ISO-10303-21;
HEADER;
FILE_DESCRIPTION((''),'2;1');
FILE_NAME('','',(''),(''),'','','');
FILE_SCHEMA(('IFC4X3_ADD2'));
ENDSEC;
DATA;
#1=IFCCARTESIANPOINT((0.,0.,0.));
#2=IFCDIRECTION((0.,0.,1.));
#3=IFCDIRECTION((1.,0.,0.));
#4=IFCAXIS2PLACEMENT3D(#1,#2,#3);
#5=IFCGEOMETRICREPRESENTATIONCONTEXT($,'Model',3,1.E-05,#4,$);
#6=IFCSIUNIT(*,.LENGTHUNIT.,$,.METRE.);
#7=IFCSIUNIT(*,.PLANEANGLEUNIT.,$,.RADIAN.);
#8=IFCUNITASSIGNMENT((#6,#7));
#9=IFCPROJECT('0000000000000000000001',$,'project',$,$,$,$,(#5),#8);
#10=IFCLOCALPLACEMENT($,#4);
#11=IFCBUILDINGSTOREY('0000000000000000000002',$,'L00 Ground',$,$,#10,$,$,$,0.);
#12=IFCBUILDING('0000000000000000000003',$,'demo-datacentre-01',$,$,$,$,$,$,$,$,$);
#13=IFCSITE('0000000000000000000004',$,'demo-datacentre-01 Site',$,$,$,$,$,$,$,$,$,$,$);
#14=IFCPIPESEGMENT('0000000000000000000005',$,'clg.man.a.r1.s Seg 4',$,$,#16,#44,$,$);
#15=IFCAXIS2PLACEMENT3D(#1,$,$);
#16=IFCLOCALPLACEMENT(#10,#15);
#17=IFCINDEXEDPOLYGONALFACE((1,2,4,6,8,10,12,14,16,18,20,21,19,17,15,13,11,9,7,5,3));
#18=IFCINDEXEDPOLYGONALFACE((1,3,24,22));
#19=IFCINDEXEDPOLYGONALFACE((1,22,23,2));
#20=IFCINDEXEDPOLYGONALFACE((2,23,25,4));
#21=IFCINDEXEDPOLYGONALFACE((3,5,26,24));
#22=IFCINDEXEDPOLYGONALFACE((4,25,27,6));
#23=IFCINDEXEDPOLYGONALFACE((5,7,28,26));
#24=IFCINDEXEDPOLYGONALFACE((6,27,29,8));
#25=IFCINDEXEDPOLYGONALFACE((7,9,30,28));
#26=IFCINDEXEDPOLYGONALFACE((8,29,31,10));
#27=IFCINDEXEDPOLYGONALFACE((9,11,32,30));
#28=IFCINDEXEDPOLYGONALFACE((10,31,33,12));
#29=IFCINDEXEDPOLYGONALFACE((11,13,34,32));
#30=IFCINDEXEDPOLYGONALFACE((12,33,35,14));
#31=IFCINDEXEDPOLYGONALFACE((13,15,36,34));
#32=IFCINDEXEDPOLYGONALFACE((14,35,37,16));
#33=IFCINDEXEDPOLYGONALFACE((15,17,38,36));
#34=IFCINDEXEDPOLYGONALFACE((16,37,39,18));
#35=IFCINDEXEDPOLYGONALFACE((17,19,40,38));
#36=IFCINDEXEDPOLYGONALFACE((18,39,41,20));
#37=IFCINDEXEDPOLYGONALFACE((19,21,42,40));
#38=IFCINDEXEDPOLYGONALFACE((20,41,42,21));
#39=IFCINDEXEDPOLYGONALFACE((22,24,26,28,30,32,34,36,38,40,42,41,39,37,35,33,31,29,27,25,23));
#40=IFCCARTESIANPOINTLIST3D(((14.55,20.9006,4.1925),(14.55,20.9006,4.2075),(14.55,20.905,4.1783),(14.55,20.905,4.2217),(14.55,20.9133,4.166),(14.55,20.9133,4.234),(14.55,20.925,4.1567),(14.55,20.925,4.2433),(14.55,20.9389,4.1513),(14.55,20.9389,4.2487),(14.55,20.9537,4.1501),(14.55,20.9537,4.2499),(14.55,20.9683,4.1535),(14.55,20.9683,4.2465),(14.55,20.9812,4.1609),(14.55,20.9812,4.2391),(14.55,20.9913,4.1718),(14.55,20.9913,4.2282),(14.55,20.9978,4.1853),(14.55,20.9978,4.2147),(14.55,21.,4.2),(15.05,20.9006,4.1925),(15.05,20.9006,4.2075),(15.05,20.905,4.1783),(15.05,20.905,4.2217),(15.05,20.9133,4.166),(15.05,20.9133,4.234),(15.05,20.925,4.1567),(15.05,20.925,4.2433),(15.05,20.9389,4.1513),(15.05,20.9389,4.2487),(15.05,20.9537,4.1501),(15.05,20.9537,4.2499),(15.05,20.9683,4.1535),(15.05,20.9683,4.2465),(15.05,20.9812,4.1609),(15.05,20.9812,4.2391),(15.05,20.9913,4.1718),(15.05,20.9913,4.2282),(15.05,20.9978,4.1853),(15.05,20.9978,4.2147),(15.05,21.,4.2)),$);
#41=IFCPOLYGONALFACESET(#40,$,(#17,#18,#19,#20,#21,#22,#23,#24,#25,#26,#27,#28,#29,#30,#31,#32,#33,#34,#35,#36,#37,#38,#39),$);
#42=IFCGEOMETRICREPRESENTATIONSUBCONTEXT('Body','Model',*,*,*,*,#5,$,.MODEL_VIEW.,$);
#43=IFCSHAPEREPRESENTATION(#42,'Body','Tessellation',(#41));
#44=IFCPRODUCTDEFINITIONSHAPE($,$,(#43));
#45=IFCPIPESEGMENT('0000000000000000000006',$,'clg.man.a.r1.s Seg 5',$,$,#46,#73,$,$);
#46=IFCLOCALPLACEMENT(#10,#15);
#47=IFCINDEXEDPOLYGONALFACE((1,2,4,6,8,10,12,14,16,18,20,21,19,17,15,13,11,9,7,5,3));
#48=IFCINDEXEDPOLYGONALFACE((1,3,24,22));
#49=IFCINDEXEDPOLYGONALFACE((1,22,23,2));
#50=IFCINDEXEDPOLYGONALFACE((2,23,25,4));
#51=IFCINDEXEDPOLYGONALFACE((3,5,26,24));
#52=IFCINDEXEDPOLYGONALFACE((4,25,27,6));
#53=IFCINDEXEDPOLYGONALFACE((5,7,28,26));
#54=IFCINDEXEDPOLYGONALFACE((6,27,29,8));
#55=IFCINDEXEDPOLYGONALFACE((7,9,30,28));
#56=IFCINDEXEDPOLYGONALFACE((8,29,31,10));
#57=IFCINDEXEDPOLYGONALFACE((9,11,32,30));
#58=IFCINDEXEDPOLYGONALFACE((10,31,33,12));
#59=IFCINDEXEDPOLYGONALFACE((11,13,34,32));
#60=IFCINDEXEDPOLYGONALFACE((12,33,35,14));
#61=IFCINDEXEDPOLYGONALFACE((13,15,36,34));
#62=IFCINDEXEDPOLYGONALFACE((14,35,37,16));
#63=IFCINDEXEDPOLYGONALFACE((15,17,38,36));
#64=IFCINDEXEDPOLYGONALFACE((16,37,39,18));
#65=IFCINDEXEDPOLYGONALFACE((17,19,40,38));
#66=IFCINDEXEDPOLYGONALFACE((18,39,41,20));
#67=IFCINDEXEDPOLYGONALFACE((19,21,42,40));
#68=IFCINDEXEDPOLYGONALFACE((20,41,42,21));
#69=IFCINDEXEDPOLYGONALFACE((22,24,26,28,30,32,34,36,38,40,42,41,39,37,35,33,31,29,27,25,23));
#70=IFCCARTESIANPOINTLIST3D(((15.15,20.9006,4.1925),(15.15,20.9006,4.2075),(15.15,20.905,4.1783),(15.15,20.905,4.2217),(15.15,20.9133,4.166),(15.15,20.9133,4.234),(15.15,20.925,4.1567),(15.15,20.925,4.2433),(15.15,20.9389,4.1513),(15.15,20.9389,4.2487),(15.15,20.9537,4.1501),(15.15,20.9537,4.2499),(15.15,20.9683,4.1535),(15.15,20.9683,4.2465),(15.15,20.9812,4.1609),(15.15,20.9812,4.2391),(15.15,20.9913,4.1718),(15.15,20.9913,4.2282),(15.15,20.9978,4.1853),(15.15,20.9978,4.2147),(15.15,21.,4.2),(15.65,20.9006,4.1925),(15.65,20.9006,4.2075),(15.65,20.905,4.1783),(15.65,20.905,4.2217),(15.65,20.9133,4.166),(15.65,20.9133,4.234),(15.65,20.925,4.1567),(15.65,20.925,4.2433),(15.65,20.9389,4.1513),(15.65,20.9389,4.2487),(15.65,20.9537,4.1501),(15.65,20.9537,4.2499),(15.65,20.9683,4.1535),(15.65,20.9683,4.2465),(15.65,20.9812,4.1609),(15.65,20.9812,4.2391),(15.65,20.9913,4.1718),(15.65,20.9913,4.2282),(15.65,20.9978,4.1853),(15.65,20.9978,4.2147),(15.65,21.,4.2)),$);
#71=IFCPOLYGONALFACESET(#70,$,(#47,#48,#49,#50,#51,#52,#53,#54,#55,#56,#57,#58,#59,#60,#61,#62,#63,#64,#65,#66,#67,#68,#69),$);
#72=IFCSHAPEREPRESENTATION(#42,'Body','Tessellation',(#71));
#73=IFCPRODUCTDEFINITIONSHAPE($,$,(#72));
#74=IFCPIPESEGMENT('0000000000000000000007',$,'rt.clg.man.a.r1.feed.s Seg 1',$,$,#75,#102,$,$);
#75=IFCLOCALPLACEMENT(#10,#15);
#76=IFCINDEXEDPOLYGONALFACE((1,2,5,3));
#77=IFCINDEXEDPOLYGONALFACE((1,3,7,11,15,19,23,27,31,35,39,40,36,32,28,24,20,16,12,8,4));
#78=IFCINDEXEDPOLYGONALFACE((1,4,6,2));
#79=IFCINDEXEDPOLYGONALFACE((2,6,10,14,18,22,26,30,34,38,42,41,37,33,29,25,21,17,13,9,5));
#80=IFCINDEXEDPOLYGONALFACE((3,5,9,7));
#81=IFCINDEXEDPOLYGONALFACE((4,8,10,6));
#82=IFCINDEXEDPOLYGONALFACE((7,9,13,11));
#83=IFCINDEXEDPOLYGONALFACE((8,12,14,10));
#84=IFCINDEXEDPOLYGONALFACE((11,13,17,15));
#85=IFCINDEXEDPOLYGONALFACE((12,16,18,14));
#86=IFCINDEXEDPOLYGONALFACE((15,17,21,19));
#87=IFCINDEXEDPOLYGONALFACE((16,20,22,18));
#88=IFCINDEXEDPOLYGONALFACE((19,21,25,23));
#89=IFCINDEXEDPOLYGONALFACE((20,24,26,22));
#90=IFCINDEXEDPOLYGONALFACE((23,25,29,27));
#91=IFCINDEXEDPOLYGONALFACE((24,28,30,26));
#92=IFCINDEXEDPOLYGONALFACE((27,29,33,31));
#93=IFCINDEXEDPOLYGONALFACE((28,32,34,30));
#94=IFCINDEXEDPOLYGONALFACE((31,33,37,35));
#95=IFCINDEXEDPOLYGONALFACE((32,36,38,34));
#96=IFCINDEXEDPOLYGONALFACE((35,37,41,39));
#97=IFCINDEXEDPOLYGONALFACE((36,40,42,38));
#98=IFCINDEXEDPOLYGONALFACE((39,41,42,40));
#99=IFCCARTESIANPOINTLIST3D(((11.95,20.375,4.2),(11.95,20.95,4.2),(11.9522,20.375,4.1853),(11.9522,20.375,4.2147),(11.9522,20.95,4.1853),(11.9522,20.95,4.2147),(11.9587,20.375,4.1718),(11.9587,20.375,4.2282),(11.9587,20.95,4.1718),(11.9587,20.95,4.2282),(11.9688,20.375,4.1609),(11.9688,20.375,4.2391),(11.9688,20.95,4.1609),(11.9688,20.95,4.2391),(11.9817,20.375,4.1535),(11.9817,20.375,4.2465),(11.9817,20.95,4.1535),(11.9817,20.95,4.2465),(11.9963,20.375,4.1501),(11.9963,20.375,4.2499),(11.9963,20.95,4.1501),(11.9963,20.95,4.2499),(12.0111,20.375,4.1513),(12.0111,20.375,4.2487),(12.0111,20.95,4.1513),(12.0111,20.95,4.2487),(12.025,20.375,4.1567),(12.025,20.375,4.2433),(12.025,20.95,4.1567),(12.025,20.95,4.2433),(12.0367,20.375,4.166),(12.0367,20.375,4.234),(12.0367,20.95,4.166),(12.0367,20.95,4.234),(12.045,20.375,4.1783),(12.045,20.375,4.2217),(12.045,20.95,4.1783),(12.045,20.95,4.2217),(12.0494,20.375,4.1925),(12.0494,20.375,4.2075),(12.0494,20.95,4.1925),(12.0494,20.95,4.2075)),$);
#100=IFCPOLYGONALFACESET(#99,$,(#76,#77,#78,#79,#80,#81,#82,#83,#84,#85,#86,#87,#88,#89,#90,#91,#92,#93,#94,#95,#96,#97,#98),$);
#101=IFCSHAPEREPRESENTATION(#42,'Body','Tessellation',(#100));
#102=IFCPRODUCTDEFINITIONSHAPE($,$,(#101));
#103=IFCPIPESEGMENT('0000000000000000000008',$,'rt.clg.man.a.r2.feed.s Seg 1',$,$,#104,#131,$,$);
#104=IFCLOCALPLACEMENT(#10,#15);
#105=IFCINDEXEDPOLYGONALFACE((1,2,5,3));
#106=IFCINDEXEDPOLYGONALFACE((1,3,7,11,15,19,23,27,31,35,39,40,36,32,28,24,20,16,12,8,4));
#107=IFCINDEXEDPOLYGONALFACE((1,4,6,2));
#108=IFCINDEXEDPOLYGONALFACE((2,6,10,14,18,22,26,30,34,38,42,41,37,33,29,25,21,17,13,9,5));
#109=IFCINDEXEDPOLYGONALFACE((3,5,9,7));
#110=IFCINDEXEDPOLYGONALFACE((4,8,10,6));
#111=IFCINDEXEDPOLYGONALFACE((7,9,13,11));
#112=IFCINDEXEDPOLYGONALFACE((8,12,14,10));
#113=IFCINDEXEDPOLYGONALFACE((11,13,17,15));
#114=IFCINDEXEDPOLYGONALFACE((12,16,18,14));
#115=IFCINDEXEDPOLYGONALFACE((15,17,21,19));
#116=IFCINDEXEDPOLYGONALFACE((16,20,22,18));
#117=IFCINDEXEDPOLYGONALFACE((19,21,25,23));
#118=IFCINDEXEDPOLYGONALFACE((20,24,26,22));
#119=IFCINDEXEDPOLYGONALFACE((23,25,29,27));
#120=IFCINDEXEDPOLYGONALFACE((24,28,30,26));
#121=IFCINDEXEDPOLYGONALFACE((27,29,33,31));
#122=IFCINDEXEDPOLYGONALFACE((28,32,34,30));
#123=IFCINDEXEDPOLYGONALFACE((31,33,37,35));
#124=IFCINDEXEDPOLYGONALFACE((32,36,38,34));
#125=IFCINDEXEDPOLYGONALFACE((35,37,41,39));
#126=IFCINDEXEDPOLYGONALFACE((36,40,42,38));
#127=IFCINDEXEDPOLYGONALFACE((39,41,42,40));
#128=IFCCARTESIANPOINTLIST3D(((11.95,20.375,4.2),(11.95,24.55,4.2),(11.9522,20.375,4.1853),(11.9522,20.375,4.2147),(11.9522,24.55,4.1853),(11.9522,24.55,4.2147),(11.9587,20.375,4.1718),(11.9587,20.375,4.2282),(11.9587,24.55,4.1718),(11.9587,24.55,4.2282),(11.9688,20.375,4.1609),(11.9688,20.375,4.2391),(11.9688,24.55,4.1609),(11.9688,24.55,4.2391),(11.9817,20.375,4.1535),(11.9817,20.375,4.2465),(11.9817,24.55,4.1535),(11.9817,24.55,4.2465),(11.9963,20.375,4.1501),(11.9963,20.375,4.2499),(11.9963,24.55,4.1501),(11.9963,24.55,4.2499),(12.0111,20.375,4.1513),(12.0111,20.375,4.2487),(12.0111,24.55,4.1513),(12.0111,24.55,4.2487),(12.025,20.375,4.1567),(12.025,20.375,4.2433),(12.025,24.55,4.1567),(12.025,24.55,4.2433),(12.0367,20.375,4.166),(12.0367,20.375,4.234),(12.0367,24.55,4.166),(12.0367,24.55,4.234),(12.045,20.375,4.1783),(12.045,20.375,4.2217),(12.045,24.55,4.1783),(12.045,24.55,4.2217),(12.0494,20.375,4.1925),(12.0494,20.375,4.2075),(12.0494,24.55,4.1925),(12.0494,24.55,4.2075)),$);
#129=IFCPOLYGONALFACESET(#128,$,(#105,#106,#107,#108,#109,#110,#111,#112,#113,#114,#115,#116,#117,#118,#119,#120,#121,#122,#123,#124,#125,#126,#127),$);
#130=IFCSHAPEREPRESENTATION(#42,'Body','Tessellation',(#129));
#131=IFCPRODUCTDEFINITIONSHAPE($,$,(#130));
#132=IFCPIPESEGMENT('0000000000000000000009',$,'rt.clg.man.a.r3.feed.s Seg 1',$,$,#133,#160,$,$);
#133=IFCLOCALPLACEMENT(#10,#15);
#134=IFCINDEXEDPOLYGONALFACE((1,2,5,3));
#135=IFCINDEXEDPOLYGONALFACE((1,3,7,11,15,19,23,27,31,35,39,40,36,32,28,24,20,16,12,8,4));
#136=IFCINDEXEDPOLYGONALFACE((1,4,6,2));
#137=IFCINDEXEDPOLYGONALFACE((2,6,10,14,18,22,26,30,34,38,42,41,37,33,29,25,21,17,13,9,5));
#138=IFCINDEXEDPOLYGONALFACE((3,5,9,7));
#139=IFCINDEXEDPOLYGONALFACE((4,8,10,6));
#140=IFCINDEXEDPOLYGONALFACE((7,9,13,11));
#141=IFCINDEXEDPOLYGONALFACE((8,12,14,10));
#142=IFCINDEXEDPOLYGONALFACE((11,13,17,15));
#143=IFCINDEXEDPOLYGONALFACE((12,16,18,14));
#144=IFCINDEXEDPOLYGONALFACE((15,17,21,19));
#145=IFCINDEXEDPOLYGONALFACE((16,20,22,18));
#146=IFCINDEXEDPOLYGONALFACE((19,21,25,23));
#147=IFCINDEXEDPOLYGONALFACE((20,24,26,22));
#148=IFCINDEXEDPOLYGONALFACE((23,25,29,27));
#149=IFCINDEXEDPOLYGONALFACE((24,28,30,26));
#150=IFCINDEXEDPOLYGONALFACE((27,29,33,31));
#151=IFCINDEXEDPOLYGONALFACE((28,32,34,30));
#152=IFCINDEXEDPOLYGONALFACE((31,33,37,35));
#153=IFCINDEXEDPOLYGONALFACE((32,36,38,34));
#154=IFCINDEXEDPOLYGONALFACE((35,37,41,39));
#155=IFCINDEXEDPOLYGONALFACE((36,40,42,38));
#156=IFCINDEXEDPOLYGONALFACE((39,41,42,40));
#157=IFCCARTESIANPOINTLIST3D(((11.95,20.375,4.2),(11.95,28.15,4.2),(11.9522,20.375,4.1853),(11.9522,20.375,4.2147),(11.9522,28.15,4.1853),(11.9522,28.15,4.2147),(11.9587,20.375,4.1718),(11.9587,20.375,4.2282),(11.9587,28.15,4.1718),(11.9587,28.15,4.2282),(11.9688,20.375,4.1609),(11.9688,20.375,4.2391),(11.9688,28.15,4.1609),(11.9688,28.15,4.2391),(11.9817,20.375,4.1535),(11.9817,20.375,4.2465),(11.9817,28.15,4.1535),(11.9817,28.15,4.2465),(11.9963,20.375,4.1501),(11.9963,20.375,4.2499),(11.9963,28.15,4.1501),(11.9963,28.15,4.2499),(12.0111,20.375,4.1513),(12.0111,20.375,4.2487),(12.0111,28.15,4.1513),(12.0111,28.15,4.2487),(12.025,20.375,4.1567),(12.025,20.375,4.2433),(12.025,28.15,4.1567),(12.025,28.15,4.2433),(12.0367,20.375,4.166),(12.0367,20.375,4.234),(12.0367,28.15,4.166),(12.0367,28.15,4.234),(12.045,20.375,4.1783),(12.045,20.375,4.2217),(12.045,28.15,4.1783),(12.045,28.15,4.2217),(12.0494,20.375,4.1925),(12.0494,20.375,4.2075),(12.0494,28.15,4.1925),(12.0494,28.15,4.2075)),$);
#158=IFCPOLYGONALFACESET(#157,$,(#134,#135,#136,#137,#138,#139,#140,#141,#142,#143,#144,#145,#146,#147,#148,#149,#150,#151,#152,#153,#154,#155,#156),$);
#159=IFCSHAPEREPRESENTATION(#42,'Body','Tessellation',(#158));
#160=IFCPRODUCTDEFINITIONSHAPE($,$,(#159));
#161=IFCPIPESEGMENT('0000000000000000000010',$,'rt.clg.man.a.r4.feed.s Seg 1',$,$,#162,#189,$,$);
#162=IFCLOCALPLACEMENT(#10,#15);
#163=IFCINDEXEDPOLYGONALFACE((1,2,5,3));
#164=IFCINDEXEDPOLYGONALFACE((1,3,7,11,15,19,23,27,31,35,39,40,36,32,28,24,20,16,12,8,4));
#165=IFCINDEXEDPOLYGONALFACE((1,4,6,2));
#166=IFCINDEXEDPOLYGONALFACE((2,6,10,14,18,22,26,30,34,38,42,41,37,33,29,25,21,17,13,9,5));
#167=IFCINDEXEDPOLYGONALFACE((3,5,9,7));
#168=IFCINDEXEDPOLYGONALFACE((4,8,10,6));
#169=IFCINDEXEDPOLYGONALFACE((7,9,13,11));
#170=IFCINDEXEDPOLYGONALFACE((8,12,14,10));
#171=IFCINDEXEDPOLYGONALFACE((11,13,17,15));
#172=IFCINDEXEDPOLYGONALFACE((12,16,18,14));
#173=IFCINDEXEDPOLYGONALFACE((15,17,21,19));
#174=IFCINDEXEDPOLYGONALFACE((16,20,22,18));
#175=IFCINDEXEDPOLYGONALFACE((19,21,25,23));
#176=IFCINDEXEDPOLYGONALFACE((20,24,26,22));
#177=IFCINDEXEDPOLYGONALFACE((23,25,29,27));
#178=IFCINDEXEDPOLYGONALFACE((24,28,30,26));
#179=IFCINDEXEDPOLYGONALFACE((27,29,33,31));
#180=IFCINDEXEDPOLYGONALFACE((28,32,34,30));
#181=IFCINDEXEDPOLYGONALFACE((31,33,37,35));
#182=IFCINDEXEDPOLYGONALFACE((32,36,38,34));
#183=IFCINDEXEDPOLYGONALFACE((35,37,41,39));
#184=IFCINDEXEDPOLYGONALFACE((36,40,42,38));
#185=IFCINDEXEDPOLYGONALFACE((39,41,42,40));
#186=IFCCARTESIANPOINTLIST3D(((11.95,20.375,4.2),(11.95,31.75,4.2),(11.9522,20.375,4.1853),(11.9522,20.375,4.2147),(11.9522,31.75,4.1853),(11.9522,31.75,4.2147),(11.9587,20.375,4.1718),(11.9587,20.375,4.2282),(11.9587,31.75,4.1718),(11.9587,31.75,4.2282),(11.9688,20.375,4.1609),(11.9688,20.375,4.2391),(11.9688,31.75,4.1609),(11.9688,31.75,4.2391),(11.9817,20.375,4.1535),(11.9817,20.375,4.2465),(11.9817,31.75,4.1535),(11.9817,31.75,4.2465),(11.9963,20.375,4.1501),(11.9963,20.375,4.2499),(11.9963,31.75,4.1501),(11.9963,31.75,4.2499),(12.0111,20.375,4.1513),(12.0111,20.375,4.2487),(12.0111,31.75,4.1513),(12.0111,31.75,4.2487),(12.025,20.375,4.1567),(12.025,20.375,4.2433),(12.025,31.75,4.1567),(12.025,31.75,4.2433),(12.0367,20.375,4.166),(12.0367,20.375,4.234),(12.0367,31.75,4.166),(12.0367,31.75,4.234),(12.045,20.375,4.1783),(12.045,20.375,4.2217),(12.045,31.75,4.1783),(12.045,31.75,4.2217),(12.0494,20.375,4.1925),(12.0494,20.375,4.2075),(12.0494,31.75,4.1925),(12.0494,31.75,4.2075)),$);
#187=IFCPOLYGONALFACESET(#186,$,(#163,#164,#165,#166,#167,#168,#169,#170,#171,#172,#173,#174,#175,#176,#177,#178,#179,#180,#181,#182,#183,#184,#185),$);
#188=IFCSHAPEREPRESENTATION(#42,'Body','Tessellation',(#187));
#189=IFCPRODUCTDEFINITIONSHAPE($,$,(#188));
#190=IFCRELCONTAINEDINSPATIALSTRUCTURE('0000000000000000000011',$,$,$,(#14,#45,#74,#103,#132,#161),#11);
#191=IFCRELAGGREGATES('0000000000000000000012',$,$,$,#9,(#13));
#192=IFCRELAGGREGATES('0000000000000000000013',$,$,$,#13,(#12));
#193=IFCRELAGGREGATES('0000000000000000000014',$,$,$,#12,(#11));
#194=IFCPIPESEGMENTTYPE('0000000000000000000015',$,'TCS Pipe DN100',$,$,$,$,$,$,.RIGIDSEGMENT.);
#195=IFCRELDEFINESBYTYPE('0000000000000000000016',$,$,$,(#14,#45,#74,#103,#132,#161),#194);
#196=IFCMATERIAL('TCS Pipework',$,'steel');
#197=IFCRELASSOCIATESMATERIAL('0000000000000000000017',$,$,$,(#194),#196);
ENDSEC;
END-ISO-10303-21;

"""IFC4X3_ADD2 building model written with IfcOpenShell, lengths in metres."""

from ifc_helpers import new_model, si_unit, frame, origin_with_axes, place, context, subcontext, project, spatial, circle, extrude, material, type_object, element, save


model = new_model("IFC4X3_ADD2")

# Units and contexts
model_context = context("Model", 3, precision=1e-05, world=origin_with_axes())
body_context = subcontext(model_context, "Body", "Model", "MODEL_VIEW")
ifc_project = project(units=[si_unit("LENGTHUNIT", "METRE"), si_unit("PLANEANGLEUNIT", "RADIAN")], contexts=[model_context])

# Site, building, storey
site = spatial("IfcSite", under=ifc_project, Name="demo-datacentre-01 Site")
building = spatial("IfcBuilding", under=site, Name="demo-datacentre-01")
storey_placement = place(None, origin_with_axes())
storey = spatial("IfcBuildingStorey", under=building, at=storey_placement, Name="L00 Ground", Elevation=0.0)

# Shared definitions
ifc_material_1 = material(Name="TCS Pipework", Category="steel")

# Pipe segments
pipe_segment_type_1 = type_object("IfcPipeSegmentType", Name="TCS Pipe DN100", PredefinedType="RIGIDSEGMENT", material=ifc_material_1)
pipe_segment_1_placement = place(storey_placement, frame((14.55, 20.95, 4.2), z_axis=(1.0, 0.0, 0.0), x_axis=(0.0, 1.0, 0.0)))
element("IfcPipeSegment", 1, at=pipe_segment_1_placement, inside=storey, type_object=pipe_segment_type_1, Name="clg.man.a.r1.s Seg 4", context=body_context, shape_type="SweptSolid", body=[
    extrude(circle(Radius=0.05), origin_with_axes(), (0.0, 0.0, 1.0), 0.5),
])
pipe_segment_2_placement = place(storey_placement, frame((15.15, 20.95, 4.2), z_axis=(1.0, 0.0, 0.0), x_axis=(0.0, 1.0, 0.0)))
element("IfcPipeSegment", 2, at=pipe_segment_2_placement, inside=storey, type_object=pipe_segment_type_1, Name="clg.man.a.r1.s Seg 5", context=body_context, shape_type="SweptSolid", body=[
    extrude(circle(Radius=0.05), origin_with_axes(), (0.0, 0.0, 1.0), 0.5),
])
pipe_segment_3_placement = place(storey_placement, frame((12.0, 20.375, 4.2), z_axis=(0.0, 1.0, 0.0), x_axis=(-1.0, 0.0, 0.0)))
element("IfcPipeSegment", 3, at=pipe_segment_3_placement, inside=storey, type_object=pipe_segment_type_1, Name="rt.clg.man.a.r1.feed.s Seg 1", context=body_context, shape_type="SweptSolid", body=[
    extrude(circle(Radius=0.05), origin_with_axes(), (0.0, 0.0, 1.0), 0.575),
])
pipe_segment_4_placement = place(storey_placement, frame((12.0, 20.375, 4.2), z_axis=(0.0, 1.0, 0.0), x_axis=(-1.0, 0.0, 0.0)))
element("IfcPipeSegment", 4, at=pipe_segment_4_placement, inside=storey, type_object=pipe_segment_type_1, Name="rt.clg.man.a.r2.feed.s Seg 1", context=body_context, shape_type="SweptSolid", body=[
    extrude(circle(Radius=0.05), origin_with_axes(), (0.0, 0.0, 1.0), 4.175),
])
pipe_segment_5_placement = place(storey_placement, frame((12.0, 20.375, 4.2), z_axis=(0.0, 1.0, 0.0), x_axis=(-1.0, 0.0, 0.0)))
element("IfcPipeSegment", 5, at=pipe_segment_5_placement, inside=storey, type_object=pipe_segment_type_1, Name="rt.clg.man.a.r3.feed.s Seg 1", context=body_context, shape_type="SweptSolid", body=[
    extrude(circle(Radius=0.05), origin_with_axes(), (0.0, 0.0, 1.0), 7.775),
])
pipe_segment_6_placement = place(storey_placement, frame((12.0, 20.375, 4.2), z_axis=(0.0, 1.0, 0.0), x_axis=(-1.0, 0.0, 0.0)))
element("IfcPipeSegment", 6, at=pipe_segment_6_placement, inside=storey, type_object=pipe_segment_type_1, Name="rt.clg.man.a.r4.feed.s Seg 1", context=body_context, shape_type="SweptSolid", body=[
    extrude(circle(Radius=0.05), origin_with_axes(), (0.0, 0.0, 1.0), 11.375),
])

save(model, "model.ifc")
